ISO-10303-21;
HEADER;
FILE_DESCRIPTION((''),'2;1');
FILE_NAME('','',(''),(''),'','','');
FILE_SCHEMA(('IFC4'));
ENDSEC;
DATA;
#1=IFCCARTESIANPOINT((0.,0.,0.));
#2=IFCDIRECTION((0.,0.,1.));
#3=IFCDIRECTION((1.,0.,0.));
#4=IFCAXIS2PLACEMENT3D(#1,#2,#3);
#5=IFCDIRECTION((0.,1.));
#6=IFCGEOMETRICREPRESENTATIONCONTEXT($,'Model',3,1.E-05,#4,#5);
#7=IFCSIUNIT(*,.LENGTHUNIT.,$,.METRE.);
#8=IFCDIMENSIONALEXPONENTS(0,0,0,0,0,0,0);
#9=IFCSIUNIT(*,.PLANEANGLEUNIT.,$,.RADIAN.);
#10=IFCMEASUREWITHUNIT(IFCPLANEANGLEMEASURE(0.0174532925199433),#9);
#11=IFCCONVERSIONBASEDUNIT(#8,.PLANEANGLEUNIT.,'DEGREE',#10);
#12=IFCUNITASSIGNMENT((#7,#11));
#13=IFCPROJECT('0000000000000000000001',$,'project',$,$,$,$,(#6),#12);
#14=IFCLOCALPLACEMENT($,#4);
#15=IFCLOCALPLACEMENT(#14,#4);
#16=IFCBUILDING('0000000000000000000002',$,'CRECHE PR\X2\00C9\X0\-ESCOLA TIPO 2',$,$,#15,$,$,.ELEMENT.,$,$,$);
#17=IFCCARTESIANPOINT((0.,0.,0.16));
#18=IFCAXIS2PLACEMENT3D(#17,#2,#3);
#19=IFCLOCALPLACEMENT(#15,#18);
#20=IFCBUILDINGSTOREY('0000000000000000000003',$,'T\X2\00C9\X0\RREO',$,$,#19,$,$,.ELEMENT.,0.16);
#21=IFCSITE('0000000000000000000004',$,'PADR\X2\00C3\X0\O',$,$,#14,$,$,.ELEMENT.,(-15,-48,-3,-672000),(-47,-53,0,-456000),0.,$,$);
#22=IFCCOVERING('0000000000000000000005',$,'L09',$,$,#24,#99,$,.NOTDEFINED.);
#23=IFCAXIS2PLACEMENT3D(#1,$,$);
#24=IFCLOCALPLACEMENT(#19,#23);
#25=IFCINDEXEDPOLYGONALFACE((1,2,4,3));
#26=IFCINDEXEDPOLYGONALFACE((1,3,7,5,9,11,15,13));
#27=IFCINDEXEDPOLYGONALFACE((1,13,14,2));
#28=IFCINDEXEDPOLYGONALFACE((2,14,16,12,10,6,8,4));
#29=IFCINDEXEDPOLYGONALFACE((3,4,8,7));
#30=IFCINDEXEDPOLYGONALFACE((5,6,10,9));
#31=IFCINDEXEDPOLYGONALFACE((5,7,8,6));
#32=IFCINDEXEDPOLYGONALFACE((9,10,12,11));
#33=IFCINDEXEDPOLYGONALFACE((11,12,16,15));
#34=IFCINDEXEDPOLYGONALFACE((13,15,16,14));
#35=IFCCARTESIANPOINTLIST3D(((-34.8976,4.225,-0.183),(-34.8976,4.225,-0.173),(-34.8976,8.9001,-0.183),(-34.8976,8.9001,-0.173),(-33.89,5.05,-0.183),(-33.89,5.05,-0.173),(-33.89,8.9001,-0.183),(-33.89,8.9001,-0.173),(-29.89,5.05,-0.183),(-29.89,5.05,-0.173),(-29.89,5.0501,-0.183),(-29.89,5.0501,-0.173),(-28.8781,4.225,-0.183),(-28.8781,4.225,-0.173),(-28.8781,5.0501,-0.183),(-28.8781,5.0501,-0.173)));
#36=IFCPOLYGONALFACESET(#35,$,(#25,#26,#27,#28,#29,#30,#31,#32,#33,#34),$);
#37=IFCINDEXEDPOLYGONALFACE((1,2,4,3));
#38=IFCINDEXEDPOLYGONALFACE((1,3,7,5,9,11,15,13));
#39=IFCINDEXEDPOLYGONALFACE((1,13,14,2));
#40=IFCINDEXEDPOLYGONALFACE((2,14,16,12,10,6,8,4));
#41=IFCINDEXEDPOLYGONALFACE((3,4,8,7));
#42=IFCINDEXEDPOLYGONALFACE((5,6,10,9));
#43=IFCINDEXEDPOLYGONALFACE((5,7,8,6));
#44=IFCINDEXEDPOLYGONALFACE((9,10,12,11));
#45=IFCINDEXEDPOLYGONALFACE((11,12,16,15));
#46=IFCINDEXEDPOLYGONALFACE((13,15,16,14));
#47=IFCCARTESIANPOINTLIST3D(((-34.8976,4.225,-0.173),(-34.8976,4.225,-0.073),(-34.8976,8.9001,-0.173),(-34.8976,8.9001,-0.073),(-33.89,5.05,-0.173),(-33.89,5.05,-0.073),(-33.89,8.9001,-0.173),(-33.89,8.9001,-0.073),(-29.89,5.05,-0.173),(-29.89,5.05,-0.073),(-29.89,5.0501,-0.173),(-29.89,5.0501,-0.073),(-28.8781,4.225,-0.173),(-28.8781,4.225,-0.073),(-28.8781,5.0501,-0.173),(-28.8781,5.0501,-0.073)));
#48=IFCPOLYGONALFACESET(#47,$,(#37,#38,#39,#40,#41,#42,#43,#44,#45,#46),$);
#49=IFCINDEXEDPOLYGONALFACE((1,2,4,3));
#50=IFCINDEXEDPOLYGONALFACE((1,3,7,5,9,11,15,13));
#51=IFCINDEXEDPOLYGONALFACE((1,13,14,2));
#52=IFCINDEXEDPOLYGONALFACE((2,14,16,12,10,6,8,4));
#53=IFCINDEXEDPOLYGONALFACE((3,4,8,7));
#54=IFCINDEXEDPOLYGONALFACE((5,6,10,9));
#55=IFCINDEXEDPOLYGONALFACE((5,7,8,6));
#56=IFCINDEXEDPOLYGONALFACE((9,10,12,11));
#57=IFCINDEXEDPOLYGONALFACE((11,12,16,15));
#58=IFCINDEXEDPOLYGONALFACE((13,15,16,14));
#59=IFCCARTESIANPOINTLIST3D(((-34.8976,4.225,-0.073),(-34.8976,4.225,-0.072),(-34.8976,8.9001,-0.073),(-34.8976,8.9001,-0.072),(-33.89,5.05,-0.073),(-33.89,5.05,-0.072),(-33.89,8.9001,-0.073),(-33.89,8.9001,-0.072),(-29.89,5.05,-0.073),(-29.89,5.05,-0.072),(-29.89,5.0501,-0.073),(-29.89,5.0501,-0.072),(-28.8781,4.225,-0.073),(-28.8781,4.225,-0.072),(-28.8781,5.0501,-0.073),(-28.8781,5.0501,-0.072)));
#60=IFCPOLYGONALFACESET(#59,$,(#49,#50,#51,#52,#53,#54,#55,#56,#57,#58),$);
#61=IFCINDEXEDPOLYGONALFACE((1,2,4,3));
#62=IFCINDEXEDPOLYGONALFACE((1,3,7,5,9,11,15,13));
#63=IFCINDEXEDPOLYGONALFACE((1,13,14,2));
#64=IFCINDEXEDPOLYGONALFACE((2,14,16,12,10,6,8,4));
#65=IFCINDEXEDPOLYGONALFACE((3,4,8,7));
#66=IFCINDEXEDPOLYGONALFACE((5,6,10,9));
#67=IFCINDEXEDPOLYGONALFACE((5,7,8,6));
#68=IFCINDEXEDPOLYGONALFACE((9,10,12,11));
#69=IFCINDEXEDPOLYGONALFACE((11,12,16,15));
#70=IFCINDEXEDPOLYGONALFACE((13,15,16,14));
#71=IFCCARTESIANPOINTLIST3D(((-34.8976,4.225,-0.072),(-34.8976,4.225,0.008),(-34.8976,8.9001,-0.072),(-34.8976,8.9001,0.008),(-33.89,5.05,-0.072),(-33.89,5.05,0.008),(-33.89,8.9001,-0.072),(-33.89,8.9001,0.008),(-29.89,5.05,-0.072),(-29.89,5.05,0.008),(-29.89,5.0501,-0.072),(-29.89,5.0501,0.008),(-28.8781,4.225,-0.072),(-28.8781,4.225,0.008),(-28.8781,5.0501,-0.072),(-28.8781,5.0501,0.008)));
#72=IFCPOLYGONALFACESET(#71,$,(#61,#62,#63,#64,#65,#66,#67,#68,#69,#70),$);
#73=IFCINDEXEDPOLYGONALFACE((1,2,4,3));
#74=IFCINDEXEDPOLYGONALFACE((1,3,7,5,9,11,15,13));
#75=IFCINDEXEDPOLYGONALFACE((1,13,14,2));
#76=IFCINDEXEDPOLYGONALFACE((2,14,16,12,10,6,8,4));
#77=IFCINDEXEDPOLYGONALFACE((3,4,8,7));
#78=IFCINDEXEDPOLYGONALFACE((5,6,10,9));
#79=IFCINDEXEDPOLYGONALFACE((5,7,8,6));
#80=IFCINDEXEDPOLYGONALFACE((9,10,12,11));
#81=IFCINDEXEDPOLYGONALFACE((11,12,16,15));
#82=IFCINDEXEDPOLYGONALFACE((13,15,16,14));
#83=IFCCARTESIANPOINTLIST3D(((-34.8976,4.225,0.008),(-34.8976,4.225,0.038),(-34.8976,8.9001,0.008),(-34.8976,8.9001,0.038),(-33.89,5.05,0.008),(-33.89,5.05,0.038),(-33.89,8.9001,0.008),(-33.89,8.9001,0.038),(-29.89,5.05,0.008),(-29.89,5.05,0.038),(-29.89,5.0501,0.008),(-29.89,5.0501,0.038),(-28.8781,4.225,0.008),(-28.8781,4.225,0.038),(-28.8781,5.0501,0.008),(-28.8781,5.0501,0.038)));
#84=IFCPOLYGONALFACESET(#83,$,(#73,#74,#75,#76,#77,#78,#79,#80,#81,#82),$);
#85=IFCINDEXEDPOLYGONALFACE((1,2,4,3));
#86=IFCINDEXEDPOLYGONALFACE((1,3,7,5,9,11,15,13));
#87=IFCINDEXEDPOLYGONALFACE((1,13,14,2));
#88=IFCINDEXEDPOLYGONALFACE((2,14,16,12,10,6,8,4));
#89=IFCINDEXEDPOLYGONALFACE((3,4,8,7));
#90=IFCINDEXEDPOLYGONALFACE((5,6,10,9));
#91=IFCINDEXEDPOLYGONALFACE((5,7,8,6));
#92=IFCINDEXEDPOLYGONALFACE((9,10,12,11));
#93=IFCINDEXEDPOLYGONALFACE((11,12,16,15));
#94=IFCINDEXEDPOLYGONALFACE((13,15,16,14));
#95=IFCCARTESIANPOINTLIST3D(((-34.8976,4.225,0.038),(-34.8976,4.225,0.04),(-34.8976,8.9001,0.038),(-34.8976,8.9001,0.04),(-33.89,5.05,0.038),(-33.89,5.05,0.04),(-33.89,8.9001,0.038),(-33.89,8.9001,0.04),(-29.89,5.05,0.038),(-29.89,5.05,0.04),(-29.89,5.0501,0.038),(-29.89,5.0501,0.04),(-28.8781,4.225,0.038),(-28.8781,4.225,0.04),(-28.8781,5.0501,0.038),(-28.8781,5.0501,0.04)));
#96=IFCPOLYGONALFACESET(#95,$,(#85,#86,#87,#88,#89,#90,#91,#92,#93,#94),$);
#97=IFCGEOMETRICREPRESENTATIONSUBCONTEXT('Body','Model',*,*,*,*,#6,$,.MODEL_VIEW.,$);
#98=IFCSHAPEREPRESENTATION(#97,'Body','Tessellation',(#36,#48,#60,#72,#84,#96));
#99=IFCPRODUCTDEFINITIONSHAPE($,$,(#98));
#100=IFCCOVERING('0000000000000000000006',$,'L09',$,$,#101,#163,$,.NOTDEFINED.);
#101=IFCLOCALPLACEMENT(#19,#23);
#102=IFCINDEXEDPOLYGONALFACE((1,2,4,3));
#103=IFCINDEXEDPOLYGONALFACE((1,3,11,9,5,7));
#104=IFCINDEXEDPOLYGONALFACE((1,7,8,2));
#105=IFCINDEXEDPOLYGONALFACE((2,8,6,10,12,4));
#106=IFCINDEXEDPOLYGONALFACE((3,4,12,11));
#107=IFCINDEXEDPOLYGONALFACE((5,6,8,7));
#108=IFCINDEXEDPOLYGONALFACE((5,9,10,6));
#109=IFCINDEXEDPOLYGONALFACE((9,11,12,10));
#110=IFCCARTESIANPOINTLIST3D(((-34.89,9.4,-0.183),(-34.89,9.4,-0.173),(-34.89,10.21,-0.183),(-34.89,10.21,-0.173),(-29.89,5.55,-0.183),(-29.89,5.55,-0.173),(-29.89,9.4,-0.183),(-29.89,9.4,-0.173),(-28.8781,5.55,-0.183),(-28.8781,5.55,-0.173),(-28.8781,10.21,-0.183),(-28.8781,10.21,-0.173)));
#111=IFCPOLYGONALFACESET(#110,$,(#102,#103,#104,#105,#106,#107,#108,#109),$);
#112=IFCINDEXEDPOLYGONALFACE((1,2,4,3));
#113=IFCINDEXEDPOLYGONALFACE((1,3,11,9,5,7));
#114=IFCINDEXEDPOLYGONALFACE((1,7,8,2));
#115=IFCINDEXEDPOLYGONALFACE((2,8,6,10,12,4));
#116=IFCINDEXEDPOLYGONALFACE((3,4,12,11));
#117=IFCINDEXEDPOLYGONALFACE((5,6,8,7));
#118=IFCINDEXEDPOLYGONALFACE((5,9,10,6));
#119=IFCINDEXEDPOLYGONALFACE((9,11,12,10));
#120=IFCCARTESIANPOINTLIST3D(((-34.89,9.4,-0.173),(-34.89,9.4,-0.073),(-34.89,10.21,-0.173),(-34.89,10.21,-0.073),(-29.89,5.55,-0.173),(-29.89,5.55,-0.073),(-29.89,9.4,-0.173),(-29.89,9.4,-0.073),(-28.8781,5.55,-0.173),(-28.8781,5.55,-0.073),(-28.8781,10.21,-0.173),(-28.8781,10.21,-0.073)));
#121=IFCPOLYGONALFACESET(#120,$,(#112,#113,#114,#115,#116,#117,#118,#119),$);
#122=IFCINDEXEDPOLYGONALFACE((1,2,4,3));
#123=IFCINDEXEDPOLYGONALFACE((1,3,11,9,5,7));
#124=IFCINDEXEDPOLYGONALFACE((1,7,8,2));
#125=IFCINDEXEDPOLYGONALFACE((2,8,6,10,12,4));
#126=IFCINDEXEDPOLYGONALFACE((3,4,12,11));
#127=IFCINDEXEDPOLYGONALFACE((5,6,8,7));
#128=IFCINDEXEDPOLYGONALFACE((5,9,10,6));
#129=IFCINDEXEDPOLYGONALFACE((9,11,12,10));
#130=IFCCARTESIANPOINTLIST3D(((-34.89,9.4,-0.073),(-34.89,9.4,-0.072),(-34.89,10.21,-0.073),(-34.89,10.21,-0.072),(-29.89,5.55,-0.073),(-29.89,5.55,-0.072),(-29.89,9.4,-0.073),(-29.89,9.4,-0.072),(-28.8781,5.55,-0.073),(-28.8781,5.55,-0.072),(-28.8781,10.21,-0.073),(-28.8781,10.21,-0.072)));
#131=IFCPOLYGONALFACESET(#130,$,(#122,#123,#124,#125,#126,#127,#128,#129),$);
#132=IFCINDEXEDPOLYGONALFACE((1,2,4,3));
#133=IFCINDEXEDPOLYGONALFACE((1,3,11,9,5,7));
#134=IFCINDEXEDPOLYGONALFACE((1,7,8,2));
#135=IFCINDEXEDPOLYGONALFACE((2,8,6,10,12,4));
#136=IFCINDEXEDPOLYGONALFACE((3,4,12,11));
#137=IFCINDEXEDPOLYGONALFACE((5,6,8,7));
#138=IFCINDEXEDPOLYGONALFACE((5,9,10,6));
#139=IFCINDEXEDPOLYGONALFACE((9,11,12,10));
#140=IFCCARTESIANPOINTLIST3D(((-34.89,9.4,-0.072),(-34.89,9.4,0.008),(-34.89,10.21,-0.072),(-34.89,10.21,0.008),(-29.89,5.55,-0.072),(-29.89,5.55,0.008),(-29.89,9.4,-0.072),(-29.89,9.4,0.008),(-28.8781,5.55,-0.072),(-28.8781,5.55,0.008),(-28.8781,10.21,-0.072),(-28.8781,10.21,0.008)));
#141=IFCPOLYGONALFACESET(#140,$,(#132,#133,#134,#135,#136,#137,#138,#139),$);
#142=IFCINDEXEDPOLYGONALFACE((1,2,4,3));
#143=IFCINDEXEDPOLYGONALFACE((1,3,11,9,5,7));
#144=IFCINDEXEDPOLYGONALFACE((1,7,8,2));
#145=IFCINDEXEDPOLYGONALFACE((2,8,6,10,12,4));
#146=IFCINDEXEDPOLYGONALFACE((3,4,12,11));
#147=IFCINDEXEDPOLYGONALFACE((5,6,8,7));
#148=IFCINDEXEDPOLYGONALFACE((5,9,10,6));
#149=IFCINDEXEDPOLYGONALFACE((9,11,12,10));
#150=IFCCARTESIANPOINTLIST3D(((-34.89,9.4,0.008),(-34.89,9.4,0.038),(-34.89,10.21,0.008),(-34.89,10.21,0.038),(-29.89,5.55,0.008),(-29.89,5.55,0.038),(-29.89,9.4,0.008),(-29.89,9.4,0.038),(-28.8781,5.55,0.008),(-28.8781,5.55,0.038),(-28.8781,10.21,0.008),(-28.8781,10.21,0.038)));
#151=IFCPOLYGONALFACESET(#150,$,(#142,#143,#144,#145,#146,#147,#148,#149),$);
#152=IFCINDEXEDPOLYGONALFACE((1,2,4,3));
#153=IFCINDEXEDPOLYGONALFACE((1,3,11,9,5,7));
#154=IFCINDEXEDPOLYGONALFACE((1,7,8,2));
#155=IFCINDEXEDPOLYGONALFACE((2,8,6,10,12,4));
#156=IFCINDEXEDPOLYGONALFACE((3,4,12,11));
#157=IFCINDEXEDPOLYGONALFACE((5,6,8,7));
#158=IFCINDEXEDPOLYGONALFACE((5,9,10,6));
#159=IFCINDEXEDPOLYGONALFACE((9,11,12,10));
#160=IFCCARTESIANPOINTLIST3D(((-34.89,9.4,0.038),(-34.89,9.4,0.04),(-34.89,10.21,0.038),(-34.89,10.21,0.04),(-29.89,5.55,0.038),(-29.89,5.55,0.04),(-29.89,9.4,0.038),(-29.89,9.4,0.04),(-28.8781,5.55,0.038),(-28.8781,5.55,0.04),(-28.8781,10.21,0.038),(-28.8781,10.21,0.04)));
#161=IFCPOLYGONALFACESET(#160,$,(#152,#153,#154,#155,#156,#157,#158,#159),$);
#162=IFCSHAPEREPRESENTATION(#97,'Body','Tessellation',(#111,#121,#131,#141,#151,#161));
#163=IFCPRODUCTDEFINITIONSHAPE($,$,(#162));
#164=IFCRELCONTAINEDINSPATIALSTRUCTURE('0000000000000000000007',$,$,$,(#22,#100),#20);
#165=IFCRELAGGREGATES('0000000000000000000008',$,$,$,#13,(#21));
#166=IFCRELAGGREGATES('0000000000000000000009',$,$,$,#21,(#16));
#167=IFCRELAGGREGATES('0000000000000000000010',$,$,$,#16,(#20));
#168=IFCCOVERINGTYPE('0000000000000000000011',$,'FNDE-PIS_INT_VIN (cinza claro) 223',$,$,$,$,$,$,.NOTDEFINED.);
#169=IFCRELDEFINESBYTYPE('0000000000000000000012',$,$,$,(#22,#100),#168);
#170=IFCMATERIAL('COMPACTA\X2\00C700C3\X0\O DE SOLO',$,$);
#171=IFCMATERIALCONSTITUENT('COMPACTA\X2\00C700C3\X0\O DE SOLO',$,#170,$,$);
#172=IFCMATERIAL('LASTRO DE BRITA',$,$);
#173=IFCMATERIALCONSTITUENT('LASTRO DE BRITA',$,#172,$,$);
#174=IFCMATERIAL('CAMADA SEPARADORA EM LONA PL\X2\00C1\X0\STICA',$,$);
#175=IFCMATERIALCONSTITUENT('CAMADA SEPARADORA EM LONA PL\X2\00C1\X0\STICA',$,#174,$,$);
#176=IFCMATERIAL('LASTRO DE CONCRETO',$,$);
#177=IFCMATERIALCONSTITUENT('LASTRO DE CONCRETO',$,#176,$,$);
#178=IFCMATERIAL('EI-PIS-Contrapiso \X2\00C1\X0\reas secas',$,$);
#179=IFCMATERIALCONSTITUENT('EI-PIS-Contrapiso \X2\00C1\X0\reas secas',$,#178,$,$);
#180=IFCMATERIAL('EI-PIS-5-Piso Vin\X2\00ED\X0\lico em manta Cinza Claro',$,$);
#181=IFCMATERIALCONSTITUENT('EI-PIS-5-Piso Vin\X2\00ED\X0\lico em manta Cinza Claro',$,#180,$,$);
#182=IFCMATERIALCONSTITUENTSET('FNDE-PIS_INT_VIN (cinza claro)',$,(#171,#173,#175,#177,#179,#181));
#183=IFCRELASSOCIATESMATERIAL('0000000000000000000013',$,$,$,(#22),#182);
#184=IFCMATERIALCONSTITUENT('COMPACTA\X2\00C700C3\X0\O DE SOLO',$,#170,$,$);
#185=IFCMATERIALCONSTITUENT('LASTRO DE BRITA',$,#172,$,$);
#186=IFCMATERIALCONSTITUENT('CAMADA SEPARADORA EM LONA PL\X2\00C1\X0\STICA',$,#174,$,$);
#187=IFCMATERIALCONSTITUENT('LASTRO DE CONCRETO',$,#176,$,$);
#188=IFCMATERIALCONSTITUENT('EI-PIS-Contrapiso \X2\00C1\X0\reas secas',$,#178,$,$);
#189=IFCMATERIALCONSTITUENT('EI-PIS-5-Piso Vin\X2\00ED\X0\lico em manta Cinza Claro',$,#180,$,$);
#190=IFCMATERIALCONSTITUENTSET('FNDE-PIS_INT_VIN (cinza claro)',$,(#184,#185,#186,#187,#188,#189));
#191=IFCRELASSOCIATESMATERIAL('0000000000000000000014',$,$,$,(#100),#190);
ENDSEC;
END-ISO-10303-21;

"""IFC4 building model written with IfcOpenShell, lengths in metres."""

from ifc_helpers import new_model, entity, si_unit, converted_unit, direction, frame, origin_with_axes, place, context, subcontext, project, spatial, line, indexed_curve, outline, extrude, material, constituent, constituent_set, type_object, element, save


model = new_model("IFC4")

# Units and contexts
model_context = context("Model", 3, precision=1e-05, world=origin_with_axes(), true_north=direction((0.0, 1.0)))
body_context = subcontext(model_context, "Body", "Model", "MODEL_VIEW")
ifc_project = project(units=[si_unit("LENGTHUNIT", "METRE"), converted_unit("PLANEANGLEUNIT", "DEGREE", entity("IfcPlaneAngleMeasure", 0.0174532925199433), si_unit("PLANEANGLEUNIT", "RADIAN"), dimensions=[0, 0, 0, 0, 0, 0, 0])], contexts=[model_context])

# Site, building, storey
site_placement = place(None, origin_with_axes())
site = spatial("IfcSite", under=ifc_project, at=site_placement, Name="PADRÃO", CompositionType="ELEMENT", RefLatitude=(-15, -48, -3, -672000), RefLongitude=(-47, -53, 0, -456000), RefElevation=0.0)
building_placement = place(site_placement, origin_with_axes())
building = spatial("IfcBuilding", under=site, at=building_placement, Name="CRECHE PRÉ-ESCOLA TIPO 2", CompositionType="ELEMENT")
storey_placement = place(building_placement, frame((0.0, 0.0, 0.16), z_axis=(0.0, 0.0, 1.0), x_axis=(1.0, 0.0, 0.0)))
storey = spatial("IfcBuildingStorey", under=building, at=storey_placement, Name="TÉRREO", CompositionType="ELEMENT", Elevation=0.16)

# Coverings
ifc_material_1 = material(Name="COMPACTAÇÃO DE SOLO")
ifc_material_2 = material(Name="LASTRO DE BRITA")
ifc_material_3 = material(Name="CAMADA SEPARADORA EM LONA PLÁSTICA")
ifc_material_4 = material(Name="LASTRO DE CONCRETO")
ifc_material_5 = material(Name="EI-PIS-Contrapiso Áreas secas")
ifc_constituent_1 = constituent(ifc_material_1, Name="COMPACTAÇÃO DE SOLO")
ifc_constituent_2 = constituent(ifc_material_2, Name="LASTRO DE BRITA")
ifc_constituent_3 = constituent(ifc_material_3, Name="CAMADA SEPARADORA EM LONA PLÁSTICA")
ifc_constituent_4 = constituent(ifc_material_4, Name="LASTRO DE CONCRETO")
ifc_constituent_5 = constituent(ifc_material_5, Name="EI-PIS-Contrapiso Áreas secas")
ifc_material_6 = material(Name="EI-PIS-5-Piso Vinílico em manta Cinza Claro")
ifc_constituent_6 = constituent(ifc_material_6, Name="EI-PIS-5-Piso Vinílico em manta Cinza Claro")
ifc_constituent_set_1 = constituent_set(constituents=[ifc_constituent_1, ifc_constituent_2, ifc_constituent_3, ifc_constituent_4, ifc_constituent_5, ifc_constituent_6], Name="FNDE-PIS_INT_VIN (cinza claro)")
covering_type_1 = type_object("IfcCoveringType", Name="FNDE-PIS_INT_VIN (cinza claro) 223", PredefinedType="NOTDEFINED")
covering_1_placement = place(storey_placement, frame((-34.8976, 4.225, 0.04), z_axis=(0.0, 0.0, 1.0), x_axis=(1.0, 0.0, 0.0)))
element("IfcCovering", 1, at=covering_1_placement, inside=storey, type_object=covering_type_1, material=ifc_constituent_set_1, Name="L09", PredefinedType="NOTDEFINED", context=body_context, shape_type="SweptSolid", body=[
    extrude(outline(indexed_curve([(0.0, 0.0), (6.0195, 0.0), (6.0195, 0.8251), (5.0075, 0.8251), (5.0075, 0.825), (1.0075, 0.825), (1.0075, 4.6751), (0.0, 4.6751)], segments=[line(1, 2, 3, 4, 5, 6, 7, 8, 1)])), frame((0.0, 0.0, -0.223), z_axis=(0.0, 0.0, 1.0), x_axis=(1.0, 0.0, 0.0)), (0.0, 0.0, 1.0), 0.01),
    extrude(outline(indexed_curve([(0.0, 0.0), (6.0195, 0.0), (6.0195, 0.8251), (5.0075, 0.8251), (5.0075, 0.825), (1.0075, 0.825), (1.0075, 4.6751), (0.0, 4.6751)], segments=[line(1, 2, 3, 4, 5, 6, 7, 8, 1)])), frame((0.0, 0.0, -0.213), z_axis=(0.0, 0.0, 1.0), x_axis=(1.0, 0.0, 0.0)), (0.0, 0.0, 1.0), 0.1),
    extrude(outline(indexed_curve([(0.0, 0.0), (6.0195, 0.0), (6.0195, 0.8251), (5.0075, 0.8251), (5.0075, 0.825), (1.0075, 0.825), (1.0075, 4.6751), (0.0, 4.6751)], segments=[line(1, 2, 3, 4, 5, 6, 7, 8, 1)])), frame((0.0, 0.0, -0.113), z_axis=(0.0, 0.0, 1.0), x_axis=(1.0, 0.0, 0.0)), (0.0, 0.0, 1.0), 0.001),
    extrude(outline(indexed_curve([(0.0, 0.0), (6.0195, 0.0), (6.0195, 0.8251), (5.0075, 0.8251), (5.0075, 0.825), (1.0075, 0.825), (1.0075, 4.6751), (0.0, 4.6751)], segments=[line(1, 2, 3, 4, 5, 6, 7, 8, 1)])), frame((0.0, 0.0, -0.112), z_axis=(0.0, 0.0, 1.0), x_axis=(1.0, 0.0, 0.0)), (0.0, 0.0, 1.0), 0.08),
    extrude(outline(indexed_curve([(0.0, 0.0), (6.0195, 0.0), (6.0195, 0.8251), (5.0075, 0.8251), (5.0075, 0.825), (1.0075, 0.825), (1.0075, 4.6751), (0.0, 4.6751)], segments=[line(1, 2, 3, 4, 5, 6, 7, 8, 1)])), frame((0.0, 0.0, -0.032), z_axis=(0.0, 0.0, 1.0), x_axis=(1.0, 0.0, 0.0)), (0.0, 0.0, 1.0), 0.03),
    extrude(outline(indexed_curve([(0.0, 0.0), (6.0195, 0.0), (6.0195, 0.8251), (5.0075, 0.8251), (5.0075, 0.825), (1.0075, 0.825), (1.0075, 4.6751), (0.0, 4.6751)], segments=[line(1, 2, 3, 4, 5, 6, 7, 8, 1)])), frame((0.0, 0.0, -0.002), z_axis=(0.0, 0.0, 1.0), x_axis=(1.0, 0.0, 0.0)), (0.0, 0.0, 1.0), 0.002),
])
ifc_constituent_7 = constituent(ifc_material_1, Name="COMPACTAÇÃO DE SOLO")
ifc_constituent_8 = constituent(ifc_material_2, Name="LASTRO DE BRITA")
ifc_constituent_9 = constituent(ifc_material_3, Name="CAMADA SEPARADORA EM LONA PLÁSTICA")
ifc_constituent_10 = constituent(ifc_material_4, Name="LASTRO DE CONCRETO")
ifc_constituent_11 = constituent(ifc_material_5, Name="EI-PIS-Contrapiso Áreas secas")
ifc_constituent_12 = constituent(ifc_material_6, Name="EI-PIS-5-Piso Vinílico em manta Cinza Claro")
ifc_constituent_set_2 = constituent_set(constituents=[ifc_constituent_7, ifc_constituent_8, ifc_constituent_9, ifc_constituent_10, ifc_constituent_11, ifc_constituent_12], Name="FNDE-PIS_INT_VIN (cinza claro)")
covering_2_placement = place(storey_placement, frame((-34.89, 9.4, 0.04), z_axis=(0.0, 0.0, 1.0), x_axis=(1.0, 0.0, 0.0)))
element("IfcCovering", 2, at=covering_2_placement, inside=storey, type_object=covering_type_1, material=ifc_constituent_set_2, Name="L09", PredefinedType="NOTDEFINED", context=body_context, shape_type="SweptSolid", body=[
    extrude(outline(indexed_curve([(0.0, 0.0), (4.9999, 0.0), (4.9999, -3.85), (6.0119, -3.85), (6.0119, 0.81), (0.0, 0.81)], segments=[line(1, 2, 3, 4, 5, 6, 1)])), frame((0.0, 0.0, -0.223), z_axis=(0.0, 0.0, 1.0), x_axis=(1.0, 0.0, 0.0)), (0.0, 0.0, 1.0), 0.01),
    extrude(outline(indexed_curve([(0.0, 0.0), (4.9999, 0.0), (4.9999, -3.85), (6.0119, -3.85), (6.0119, 0.81), (0.0, 0.81)], segments=[line(1, 2, 3, 4, 5, 6, 1)])), frame((0.0, 0.0, -0.213), z_axis=(0.0, 0.0, 1.0), x_axis=(1.0, 0.0, 0.0)), (0.0, 0.0, 1.0), 0.1),
    extrude(outline(indexed_curve([(0.0, 0.0), (4.9999, 0.0), (4.9999, -3.85), (6.0119, -3.85), (6.0119, 0.81), (0.0, 0.81)], segments=[line(1, 2, 3, 4, 5, 6, 1)])), frame((0.0, 0.0, -0.113), z_axis=(0.0, 0.0, 1.0), x_axis=(1.0, 0.0, 0.0)), (0.0, 0.0, 1.0), 0.001),
    extrude(outline(indexed_curve([(0.0, 0.0), (4.9999, 0.0), (4.9999, -3.85), (6.0119, -3.85), (6.0119, 0.81), (0.0, 0.81)], segments=[line(1, 2, 3, 4, 5, 6, 1)])), frame((0.0, 0.0, -0.112), z_axis=(0.0, 0.0, 1.0), x_axis=(1.0, 0.0, 0.0)), (0.0, 0.0, 1.0), 0.08),
    extrude(outline(indexed_curve([(0.0, 0.0), (4.9999, 0.0), (4.9999, -3.85), (6.0119, -3.85), (6.0119, 0.81), (0.0, 0.81)], segments=[line(1, 2, 3, 4, 5, 6, 1)])), frame((0.0, 0.0, -0.032), z_axis=(0.0, 0.0, 1.0), x_axis=(1.0, 0.0, 0.0)), (0.0, 0.0, 1.0), 0.03),
    extrude(outline(indexed_curve([(0.0, 0.0), (4.9999, 0.0), (4.9999, -3.85), (6.0119, -3.85), (6.0119, 0.81), (0.0, 0.81)], segments=[line(1, 2, 3, 4, 5, 6, 1)])), frame((0.0, 0.0, -0.002), z_axis=(0.0, 0.0, 1.0), x_axis=(1.0, 0.0, 0.0)), (0.0, 0.0, 1.0), 0.002),
])

save(model, "model.ifc")
